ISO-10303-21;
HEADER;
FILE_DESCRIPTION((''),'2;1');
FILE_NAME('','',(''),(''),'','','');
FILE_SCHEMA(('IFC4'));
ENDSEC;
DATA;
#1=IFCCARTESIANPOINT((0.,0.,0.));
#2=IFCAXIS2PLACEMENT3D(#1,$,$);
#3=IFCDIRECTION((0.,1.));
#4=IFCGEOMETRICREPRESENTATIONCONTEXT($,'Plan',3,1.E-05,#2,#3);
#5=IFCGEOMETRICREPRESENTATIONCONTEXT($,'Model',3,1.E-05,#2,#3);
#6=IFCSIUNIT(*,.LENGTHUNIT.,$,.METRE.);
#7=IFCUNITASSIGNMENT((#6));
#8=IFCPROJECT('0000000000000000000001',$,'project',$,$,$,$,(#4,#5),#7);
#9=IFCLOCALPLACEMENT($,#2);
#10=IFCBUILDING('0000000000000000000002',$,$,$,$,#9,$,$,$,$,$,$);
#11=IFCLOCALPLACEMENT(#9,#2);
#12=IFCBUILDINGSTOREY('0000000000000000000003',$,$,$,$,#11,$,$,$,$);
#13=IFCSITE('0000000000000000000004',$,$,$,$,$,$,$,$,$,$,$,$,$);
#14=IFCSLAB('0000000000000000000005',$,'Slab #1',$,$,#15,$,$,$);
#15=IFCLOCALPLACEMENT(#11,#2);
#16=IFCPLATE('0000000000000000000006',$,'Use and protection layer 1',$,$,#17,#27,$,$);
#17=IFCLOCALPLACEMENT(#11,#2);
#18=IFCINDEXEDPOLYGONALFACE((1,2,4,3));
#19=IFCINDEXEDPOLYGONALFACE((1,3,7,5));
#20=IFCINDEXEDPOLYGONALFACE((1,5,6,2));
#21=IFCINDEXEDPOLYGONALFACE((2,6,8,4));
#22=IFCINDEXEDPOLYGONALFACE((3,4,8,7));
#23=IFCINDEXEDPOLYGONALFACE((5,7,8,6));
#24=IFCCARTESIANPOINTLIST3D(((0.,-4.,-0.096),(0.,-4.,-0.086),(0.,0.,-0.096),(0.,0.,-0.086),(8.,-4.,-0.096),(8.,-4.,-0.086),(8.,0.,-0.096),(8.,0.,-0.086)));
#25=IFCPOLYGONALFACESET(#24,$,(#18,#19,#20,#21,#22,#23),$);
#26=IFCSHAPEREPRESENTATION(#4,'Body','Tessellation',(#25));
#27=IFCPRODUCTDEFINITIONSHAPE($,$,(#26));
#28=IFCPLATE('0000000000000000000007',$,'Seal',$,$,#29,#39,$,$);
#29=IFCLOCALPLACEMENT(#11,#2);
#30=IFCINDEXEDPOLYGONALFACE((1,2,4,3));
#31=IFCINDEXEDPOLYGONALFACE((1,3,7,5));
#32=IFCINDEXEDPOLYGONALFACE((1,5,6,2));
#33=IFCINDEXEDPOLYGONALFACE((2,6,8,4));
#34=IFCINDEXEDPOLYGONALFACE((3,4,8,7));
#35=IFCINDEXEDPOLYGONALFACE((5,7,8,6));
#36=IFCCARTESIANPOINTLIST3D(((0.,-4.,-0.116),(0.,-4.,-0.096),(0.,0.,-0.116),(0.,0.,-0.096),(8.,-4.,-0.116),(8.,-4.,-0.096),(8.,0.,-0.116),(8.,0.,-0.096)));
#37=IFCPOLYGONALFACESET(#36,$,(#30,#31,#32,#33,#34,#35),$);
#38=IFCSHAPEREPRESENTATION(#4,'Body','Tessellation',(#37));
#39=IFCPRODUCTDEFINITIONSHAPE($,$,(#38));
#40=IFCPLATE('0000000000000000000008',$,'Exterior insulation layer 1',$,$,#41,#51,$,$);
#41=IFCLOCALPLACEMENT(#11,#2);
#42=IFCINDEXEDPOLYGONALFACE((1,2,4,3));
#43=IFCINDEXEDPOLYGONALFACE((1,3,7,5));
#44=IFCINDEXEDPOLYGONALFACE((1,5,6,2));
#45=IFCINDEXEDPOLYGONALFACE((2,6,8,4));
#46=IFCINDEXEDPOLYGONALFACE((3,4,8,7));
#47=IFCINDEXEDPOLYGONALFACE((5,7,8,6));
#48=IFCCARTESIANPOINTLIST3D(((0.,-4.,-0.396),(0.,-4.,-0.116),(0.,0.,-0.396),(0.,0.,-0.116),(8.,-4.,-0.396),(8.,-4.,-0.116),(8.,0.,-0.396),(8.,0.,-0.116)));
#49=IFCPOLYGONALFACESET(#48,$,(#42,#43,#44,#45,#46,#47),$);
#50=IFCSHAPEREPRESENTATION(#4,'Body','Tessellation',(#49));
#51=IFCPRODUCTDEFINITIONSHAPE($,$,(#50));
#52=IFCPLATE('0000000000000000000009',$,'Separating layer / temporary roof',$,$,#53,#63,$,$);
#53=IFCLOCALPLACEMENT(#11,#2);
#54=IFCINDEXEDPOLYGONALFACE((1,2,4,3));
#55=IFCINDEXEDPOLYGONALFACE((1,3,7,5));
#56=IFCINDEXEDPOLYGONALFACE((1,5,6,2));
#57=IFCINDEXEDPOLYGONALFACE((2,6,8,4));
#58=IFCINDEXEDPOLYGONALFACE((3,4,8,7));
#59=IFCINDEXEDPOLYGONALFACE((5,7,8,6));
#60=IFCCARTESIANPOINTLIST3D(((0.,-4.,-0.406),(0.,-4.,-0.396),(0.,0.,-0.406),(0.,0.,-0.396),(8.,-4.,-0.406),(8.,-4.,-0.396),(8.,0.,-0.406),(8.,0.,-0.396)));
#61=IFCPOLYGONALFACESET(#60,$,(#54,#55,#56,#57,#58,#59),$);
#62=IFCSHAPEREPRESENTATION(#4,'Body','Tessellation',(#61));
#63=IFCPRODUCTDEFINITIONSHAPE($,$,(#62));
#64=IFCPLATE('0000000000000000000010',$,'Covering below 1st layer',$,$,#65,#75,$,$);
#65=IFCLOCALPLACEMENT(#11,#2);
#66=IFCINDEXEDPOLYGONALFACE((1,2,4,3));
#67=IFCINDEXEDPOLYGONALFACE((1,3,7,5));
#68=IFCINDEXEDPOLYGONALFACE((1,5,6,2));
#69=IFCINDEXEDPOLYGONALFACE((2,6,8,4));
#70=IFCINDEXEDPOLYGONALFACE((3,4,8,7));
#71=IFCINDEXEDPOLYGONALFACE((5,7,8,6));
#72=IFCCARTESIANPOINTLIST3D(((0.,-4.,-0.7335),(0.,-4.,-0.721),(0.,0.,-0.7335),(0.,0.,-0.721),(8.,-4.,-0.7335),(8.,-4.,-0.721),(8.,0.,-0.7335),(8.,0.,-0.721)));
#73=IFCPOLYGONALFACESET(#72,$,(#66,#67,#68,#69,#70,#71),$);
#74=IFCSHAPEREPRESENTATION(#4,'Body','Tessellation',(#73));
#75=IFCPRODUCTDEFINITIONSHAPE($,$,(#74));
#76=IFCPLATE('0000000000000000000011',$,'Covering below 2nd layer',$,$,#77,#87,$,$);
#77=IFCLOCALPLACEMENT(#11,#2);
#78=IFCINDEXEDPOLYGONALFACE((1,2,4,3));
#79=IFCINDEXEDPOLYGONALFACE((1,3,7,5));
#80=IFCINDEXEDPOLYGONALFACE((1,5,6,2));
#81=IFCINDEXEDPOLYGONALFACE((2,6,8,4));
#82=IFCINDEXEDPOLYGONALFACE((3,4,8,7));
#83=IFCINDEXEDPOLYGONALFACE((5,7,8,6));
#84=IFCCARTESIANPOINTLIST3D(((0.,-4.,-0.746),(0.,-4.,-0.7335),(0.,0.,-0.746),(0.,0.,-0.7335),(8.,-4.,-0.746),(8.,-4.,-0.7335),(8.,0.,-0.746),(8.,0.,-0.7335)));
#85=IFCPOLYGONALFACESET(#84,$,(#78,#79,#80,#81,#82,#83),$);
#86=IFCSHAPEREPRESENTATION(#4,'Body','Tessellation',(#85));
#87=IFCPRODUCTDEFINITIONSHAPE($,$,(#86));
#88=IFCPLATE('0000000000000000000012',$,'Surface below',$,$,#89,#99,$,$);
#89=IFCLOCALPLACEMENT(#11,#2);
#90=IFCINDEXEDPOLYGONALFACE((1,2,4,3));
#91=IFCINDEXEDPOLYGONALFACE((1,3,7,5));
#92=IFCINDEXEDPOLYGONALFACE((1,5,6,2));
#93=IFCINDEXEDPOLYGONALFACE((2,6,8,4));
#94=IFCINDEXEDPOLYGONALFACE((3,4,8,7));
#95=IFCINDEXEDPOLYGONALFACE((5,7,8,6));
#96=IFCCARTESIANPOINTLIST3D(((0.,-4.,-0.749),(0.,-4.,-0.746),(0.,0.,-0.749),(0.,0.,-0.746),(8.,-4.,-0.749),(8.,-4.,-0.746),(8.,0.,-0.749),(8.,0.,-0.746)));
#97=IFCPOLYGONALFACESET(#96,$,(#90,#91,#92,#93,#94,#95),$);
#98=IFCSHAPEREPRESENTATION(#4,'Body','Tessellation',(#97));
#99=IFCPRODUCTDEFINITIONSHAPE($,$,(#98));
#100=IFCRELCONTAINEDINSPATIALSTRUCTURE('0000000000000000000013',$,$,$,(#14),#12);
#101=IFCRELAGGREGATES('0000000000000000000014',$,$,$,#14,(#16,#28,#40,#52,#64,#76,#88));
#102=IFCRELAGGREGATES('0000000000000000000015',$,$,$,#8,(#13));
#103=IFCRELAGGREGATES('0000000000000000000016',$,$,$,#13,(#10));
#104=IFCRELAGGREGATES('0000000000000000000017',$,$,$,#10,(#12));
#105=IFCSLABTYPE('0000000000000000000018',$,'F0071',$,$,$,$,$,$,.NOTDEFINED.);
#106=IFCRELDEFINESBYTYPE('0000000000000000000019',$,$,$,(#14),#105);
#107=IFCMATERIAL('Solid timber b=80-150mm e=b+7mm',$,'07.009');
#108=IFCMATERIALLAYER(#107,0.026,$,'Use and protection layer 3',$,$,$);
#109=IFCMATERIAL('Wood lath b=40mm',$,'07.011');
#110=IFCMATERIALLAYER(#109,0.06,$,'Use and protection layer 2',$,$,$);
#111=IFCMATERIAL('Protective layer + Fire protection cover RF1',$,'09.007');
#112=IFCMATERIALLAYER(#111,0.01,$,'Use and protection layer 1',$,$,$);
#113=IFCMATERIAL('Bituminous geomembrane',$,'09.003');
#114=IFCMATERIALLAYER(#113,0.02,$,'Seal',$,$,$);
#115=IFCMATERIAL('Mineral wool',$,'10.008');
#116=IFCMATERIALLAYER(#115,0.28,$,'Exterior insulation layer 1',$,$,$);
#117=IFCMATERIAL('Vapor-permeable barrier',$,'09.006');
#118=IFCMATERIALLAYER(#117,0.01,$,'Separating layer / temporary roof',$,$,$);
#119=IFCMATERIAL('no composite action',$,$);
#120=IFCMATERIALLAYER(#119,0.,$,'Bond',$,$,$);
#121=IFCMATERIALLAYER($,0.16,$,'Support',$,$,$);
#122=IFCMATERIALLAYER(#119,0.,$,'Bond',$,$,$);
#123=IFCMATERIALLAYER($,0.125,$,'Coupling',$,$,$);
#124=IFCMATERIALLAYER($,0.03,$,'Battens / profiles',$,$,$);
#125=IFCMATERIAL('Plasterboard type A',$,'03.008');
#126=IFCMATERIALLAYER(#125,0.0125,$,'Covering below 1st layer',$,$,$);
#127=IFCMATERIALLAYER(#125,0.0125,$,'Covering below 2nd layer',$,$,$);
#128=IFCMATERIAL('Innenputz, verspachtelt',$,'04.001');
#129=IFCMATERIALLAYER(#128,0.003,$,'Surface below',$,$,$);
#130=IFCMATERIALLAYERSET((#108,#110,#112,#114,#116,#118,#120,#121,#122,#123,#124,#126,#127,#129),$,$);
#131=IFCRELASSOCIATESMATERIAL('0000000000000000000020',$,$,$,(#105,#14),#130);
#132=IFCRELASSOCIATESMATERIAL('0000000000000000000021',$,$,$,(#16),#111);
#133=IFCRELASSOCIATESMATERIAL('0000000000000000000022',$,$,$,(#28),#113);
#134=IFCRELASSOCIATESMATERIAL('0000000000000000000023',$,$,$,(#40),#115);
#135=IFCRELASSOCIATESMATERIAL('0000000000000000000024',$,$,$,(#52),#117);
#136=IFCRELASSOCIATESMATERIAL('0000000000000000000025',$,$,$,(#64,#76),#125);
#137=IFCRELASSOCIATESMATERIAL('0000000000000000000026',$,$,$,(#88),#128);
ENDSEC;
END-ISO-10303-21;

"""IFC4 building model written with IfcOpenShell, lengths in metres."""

from ifc_helpers import new_model, si_unit, direction, frame, frame_2d, origin, place, context, project, spatial, rectangle, extrude, material, layer, layer_set, type_object, element, aggregate, save


model = new_model("IFC4")

# Units and contexts
plan_context = context("Plan", 3, precision=1e-05, world=origin(), true_north=direction((0.0, 1.0)))
model_context = context("Model", 3, precision=1e-05, world=origin(), true_north=direction((0.0, 1.0)))
ifc_project = project(units=[si_unit("LENGTHUNIT", "METRE")], contexts=[plan_context, model_context])

# Site, building, storey
site = spatial("IfcSite", under=ifc_project)
building_placement = place(None, origin())
building = spatial("IfcBuilding", under=site, at=building_placement)
storey_placement = place(building_placement, origin())
storey = spatial("IfcBuildingStorey", under=building, at=storey_placement)

# Slab, plates
ifc_material_1 = material(Name="Solid timber b=80-150mm e=b+7mm", Category="07.009")
ifc_layer_1 = layer(ifc_material_1, 0.026, Name="Use and protection layer 3")
ifc_material_2 = material(Name="Wood lath b=40mm", Category="07.011")
ifc_layer_2 = layer(ifc_material_2, 0.06, Name="Use and protection layer 2")
ifc_material_3 = material(Name="Protective layer + Fire protection cover RF1", Category="09.007")
ifc_layer_3 = layer(ifc_material_3, 0.01, Name="Use and protection layer 1")
ifc_material_4 = material(Name="Bituminous geomembrane", Category="09.003")
ifc_layer_4 = layer(ifc_material_4, 0.02, Name="Seal")
ifc_material_5 = material(Name="Mineral wool", Category="10.008")
ifc_layer_5 = layer(ifc_material_5, 0.28, Name="Exterior insulation layer 1")
ifc_material_6 = material(Name="Vapor-permeable barrier", Category="09.006")
ifc_layer_6 = layer(ifc_material_6, 0.01, Name="Separating layer / temporary roof")
ifc_material_7 = material(Name="no composite action")
ifc_layer_7 = layer(ifc_material_7, 0.0, Name="Bond")
ifc_layer_8 = layer(None, 0.16, Name="Support")
ifc_layer_9 = layer(ifc_material_7, 0.0, Name="Bond")
ifc_layer_10 = layer(None, 0.125, Name="Coupling")
ifc_layer_11 = layer(None, 0.03, Name="Battens / profiles")
ifc_material_8 = material(Name="Plasterboard type A", Category="03.008")
ifc_layer_12 = layer(ifc_material_8, 0.0125, Name="Covering below 1st layer")
ifc_layer_13 = layer(ifc_material_8, 0.0125, Name="Covering below 2nd layer")
ifc_material_9 = material(Name="Innenputz, verspachtelt", Category="04.001")
ifc_layer_14 = layer(ifc_material_9, 0.003, Name="Surface below")
ifc_layer_set = layer_set([ifc_layer_1, ifc_layer_2, ifc_layer_3, ifc_layer_4, ifc_layer_5, ifc_layer_6, ifc_layer_7, ifc_layer_8, ifc_layer_9, ifc_layer_10, ifc_layer_11, ifc_layer_12, ifc_layer_13, ifc_layer_14])
slab_type = type_object("IfcSlabType", Name="F0071", PredefinedType="NOTDEFINED", material=ifc_layer_set)
slab_placement = place(None, frame((0.0, 0.0, 0.0), z_axis=(0.0, 0.0, -1.0), x_axis=(1.0, 0.0, 0.0)))
slab = element("IfcSlab", 1, at=slab_placement, inside=storey, type_object=slab_type, material=ifc_layer_set, Name="Slab #1")
plate_1_placement = place(slab_placement, origin())
plate_1 = element("IfcPlate", 2, at=plate_1_placement, material=ifc_material_3, Name="Use and protection layer 1", context=plan_context, shape_type="SweptSolid", body=[
    extrude(rectangle(XDim=8.0, YDim=4.0, at=frame_2d((4.0, 2.0), x_axis=(1.0, 0.0))), frame((0.0, 0.0, 0.086), z_axis=(0.0, 0.0, 1.0), x_axis=(1.0, 0.0, 0.0)), (0.0, 0.0, 1.0), 0.01),
])
plate_2_placement = place(slab_placement, origin())
plate_2 = element("IfcPlate", 3, at=plate_2_placement, material=ifc_material_4, Name="Seal", context=plan_context, shape_type="SweptSolid", body=[
    extrude(rectangle(XDim=8.0, YDim=4.0, at=frame_2d((4.0, 2.0), x_axis=(1.0, 0.0))), frame((0.0, 0.0, 0.096), z_axis=(0.0, 0.0, 1.0), x_axis=(1.0, 0.0, 0.0)), (0.0, 0.0, 1.0), 0.02),
])
plate_3_placement = place(slab_placement, origin())
plate_3 = element("IfcPlate", 4, at=plate_3_placement, material=ifc_material_5, Name="Exterior insulation layer 1", context=plan_context, shape_type="SweptSolid", body=[
    extrude(rectangle(XDim=8.0, YDim=4.0, at=frame_2d((4.0, 2.0), x_axis=(1.0, 0.0))), frame((0.0, 0.0, 0.116), z_axis=(0.0, 0.0, 1.0), x_axis=(1.0, 0.0, 0.0)), (0.0, 0.0, 1.0), 0.28),
])
plate_4_placement = place(slab_placement, origin())
plate_4 = element("IfcPlate", 5, at=plate_4_placement, material=ifc_material_6, Name="Separating layer / temporary roof", context=plan_context, shape_type="SweptSolid", body=[
    extrude(rectangle(XDim=8.0, YDim=4.0, at=frame_2d((4.0, 2.0), x_axis=(1.0, 0.0))), frame((0.0, 0.0, 0.396), z_axis=(0.0, 0.0, 1.0), x_axis=(1.0, 0.0, 0.0)), (0.0, 0.0, 1.0), 0.01),
])
plate_5_placement = place(slab_placement, origin())
plate_5 = element("IfcPlate", 6, at=plate_5_placement, material=ifc_material_8, Name="Covering below 1st layer", context=plan_context, shape_type="SweptSolid", body=[
    extrude(rectangle(XDim=8.0, YDim=4.0, at=frame_2d((4.0, 2.0), x_axis=(1.0, 0.0))), frame((0.0, 0.0, 0.721), z_axis=(0.0, 0.0, 1.0), x_axis=(1.0, 0.0, 0.0)), (0.0, 0.0, 1.0), 0.0125),
])
plate_6_placement = place(slab_placement, origin())
plate_6 = element("IfcPlate", 7, at=plate_6_placement, material=ifc_material_8, Name="Covering below 2nd layer", context=plan_context, shape_type="SweptSolid", body=[
    extrude(rectangle(XDim=8.0, YDim=4.0, at=frame_2d((4.0, 2.0), x_axis=(1.0, 0.0))), frame((0.0, 0.0, 0.7335), z_axis=(0.0, 0.0, 1.0), x_axis=(1.0, 0.0, 0.0)), (0.0, 0.0, 1.0), 0.0125),
])
plate_7_placement = place(slab_placement, origin())
plate_7 = element("IfcPlate", 8, at=plate_7_placement, material=ifc_material_9, Name="Surface below", context=plan_context, shape_type="SweptSolid", body=[
    extrude(rectangle(XDim=8.0, YDim=4.0, at=frame_2d((4.0, 2.0), x_axis=(1.0, 0.0))), frame((0.0, 0.0, 0.746), z_axis=(0.0, 0.0, 1.0), x_axis=(1.0, 0.0, 0.0)), (0.0, 0.0, 1.0), 0.003),
])
aggregate(slab, [plate_1, plate_2, plate_3, plate_4, plate_5, plate_6, plate_7])

save(model, "model.ifc")
